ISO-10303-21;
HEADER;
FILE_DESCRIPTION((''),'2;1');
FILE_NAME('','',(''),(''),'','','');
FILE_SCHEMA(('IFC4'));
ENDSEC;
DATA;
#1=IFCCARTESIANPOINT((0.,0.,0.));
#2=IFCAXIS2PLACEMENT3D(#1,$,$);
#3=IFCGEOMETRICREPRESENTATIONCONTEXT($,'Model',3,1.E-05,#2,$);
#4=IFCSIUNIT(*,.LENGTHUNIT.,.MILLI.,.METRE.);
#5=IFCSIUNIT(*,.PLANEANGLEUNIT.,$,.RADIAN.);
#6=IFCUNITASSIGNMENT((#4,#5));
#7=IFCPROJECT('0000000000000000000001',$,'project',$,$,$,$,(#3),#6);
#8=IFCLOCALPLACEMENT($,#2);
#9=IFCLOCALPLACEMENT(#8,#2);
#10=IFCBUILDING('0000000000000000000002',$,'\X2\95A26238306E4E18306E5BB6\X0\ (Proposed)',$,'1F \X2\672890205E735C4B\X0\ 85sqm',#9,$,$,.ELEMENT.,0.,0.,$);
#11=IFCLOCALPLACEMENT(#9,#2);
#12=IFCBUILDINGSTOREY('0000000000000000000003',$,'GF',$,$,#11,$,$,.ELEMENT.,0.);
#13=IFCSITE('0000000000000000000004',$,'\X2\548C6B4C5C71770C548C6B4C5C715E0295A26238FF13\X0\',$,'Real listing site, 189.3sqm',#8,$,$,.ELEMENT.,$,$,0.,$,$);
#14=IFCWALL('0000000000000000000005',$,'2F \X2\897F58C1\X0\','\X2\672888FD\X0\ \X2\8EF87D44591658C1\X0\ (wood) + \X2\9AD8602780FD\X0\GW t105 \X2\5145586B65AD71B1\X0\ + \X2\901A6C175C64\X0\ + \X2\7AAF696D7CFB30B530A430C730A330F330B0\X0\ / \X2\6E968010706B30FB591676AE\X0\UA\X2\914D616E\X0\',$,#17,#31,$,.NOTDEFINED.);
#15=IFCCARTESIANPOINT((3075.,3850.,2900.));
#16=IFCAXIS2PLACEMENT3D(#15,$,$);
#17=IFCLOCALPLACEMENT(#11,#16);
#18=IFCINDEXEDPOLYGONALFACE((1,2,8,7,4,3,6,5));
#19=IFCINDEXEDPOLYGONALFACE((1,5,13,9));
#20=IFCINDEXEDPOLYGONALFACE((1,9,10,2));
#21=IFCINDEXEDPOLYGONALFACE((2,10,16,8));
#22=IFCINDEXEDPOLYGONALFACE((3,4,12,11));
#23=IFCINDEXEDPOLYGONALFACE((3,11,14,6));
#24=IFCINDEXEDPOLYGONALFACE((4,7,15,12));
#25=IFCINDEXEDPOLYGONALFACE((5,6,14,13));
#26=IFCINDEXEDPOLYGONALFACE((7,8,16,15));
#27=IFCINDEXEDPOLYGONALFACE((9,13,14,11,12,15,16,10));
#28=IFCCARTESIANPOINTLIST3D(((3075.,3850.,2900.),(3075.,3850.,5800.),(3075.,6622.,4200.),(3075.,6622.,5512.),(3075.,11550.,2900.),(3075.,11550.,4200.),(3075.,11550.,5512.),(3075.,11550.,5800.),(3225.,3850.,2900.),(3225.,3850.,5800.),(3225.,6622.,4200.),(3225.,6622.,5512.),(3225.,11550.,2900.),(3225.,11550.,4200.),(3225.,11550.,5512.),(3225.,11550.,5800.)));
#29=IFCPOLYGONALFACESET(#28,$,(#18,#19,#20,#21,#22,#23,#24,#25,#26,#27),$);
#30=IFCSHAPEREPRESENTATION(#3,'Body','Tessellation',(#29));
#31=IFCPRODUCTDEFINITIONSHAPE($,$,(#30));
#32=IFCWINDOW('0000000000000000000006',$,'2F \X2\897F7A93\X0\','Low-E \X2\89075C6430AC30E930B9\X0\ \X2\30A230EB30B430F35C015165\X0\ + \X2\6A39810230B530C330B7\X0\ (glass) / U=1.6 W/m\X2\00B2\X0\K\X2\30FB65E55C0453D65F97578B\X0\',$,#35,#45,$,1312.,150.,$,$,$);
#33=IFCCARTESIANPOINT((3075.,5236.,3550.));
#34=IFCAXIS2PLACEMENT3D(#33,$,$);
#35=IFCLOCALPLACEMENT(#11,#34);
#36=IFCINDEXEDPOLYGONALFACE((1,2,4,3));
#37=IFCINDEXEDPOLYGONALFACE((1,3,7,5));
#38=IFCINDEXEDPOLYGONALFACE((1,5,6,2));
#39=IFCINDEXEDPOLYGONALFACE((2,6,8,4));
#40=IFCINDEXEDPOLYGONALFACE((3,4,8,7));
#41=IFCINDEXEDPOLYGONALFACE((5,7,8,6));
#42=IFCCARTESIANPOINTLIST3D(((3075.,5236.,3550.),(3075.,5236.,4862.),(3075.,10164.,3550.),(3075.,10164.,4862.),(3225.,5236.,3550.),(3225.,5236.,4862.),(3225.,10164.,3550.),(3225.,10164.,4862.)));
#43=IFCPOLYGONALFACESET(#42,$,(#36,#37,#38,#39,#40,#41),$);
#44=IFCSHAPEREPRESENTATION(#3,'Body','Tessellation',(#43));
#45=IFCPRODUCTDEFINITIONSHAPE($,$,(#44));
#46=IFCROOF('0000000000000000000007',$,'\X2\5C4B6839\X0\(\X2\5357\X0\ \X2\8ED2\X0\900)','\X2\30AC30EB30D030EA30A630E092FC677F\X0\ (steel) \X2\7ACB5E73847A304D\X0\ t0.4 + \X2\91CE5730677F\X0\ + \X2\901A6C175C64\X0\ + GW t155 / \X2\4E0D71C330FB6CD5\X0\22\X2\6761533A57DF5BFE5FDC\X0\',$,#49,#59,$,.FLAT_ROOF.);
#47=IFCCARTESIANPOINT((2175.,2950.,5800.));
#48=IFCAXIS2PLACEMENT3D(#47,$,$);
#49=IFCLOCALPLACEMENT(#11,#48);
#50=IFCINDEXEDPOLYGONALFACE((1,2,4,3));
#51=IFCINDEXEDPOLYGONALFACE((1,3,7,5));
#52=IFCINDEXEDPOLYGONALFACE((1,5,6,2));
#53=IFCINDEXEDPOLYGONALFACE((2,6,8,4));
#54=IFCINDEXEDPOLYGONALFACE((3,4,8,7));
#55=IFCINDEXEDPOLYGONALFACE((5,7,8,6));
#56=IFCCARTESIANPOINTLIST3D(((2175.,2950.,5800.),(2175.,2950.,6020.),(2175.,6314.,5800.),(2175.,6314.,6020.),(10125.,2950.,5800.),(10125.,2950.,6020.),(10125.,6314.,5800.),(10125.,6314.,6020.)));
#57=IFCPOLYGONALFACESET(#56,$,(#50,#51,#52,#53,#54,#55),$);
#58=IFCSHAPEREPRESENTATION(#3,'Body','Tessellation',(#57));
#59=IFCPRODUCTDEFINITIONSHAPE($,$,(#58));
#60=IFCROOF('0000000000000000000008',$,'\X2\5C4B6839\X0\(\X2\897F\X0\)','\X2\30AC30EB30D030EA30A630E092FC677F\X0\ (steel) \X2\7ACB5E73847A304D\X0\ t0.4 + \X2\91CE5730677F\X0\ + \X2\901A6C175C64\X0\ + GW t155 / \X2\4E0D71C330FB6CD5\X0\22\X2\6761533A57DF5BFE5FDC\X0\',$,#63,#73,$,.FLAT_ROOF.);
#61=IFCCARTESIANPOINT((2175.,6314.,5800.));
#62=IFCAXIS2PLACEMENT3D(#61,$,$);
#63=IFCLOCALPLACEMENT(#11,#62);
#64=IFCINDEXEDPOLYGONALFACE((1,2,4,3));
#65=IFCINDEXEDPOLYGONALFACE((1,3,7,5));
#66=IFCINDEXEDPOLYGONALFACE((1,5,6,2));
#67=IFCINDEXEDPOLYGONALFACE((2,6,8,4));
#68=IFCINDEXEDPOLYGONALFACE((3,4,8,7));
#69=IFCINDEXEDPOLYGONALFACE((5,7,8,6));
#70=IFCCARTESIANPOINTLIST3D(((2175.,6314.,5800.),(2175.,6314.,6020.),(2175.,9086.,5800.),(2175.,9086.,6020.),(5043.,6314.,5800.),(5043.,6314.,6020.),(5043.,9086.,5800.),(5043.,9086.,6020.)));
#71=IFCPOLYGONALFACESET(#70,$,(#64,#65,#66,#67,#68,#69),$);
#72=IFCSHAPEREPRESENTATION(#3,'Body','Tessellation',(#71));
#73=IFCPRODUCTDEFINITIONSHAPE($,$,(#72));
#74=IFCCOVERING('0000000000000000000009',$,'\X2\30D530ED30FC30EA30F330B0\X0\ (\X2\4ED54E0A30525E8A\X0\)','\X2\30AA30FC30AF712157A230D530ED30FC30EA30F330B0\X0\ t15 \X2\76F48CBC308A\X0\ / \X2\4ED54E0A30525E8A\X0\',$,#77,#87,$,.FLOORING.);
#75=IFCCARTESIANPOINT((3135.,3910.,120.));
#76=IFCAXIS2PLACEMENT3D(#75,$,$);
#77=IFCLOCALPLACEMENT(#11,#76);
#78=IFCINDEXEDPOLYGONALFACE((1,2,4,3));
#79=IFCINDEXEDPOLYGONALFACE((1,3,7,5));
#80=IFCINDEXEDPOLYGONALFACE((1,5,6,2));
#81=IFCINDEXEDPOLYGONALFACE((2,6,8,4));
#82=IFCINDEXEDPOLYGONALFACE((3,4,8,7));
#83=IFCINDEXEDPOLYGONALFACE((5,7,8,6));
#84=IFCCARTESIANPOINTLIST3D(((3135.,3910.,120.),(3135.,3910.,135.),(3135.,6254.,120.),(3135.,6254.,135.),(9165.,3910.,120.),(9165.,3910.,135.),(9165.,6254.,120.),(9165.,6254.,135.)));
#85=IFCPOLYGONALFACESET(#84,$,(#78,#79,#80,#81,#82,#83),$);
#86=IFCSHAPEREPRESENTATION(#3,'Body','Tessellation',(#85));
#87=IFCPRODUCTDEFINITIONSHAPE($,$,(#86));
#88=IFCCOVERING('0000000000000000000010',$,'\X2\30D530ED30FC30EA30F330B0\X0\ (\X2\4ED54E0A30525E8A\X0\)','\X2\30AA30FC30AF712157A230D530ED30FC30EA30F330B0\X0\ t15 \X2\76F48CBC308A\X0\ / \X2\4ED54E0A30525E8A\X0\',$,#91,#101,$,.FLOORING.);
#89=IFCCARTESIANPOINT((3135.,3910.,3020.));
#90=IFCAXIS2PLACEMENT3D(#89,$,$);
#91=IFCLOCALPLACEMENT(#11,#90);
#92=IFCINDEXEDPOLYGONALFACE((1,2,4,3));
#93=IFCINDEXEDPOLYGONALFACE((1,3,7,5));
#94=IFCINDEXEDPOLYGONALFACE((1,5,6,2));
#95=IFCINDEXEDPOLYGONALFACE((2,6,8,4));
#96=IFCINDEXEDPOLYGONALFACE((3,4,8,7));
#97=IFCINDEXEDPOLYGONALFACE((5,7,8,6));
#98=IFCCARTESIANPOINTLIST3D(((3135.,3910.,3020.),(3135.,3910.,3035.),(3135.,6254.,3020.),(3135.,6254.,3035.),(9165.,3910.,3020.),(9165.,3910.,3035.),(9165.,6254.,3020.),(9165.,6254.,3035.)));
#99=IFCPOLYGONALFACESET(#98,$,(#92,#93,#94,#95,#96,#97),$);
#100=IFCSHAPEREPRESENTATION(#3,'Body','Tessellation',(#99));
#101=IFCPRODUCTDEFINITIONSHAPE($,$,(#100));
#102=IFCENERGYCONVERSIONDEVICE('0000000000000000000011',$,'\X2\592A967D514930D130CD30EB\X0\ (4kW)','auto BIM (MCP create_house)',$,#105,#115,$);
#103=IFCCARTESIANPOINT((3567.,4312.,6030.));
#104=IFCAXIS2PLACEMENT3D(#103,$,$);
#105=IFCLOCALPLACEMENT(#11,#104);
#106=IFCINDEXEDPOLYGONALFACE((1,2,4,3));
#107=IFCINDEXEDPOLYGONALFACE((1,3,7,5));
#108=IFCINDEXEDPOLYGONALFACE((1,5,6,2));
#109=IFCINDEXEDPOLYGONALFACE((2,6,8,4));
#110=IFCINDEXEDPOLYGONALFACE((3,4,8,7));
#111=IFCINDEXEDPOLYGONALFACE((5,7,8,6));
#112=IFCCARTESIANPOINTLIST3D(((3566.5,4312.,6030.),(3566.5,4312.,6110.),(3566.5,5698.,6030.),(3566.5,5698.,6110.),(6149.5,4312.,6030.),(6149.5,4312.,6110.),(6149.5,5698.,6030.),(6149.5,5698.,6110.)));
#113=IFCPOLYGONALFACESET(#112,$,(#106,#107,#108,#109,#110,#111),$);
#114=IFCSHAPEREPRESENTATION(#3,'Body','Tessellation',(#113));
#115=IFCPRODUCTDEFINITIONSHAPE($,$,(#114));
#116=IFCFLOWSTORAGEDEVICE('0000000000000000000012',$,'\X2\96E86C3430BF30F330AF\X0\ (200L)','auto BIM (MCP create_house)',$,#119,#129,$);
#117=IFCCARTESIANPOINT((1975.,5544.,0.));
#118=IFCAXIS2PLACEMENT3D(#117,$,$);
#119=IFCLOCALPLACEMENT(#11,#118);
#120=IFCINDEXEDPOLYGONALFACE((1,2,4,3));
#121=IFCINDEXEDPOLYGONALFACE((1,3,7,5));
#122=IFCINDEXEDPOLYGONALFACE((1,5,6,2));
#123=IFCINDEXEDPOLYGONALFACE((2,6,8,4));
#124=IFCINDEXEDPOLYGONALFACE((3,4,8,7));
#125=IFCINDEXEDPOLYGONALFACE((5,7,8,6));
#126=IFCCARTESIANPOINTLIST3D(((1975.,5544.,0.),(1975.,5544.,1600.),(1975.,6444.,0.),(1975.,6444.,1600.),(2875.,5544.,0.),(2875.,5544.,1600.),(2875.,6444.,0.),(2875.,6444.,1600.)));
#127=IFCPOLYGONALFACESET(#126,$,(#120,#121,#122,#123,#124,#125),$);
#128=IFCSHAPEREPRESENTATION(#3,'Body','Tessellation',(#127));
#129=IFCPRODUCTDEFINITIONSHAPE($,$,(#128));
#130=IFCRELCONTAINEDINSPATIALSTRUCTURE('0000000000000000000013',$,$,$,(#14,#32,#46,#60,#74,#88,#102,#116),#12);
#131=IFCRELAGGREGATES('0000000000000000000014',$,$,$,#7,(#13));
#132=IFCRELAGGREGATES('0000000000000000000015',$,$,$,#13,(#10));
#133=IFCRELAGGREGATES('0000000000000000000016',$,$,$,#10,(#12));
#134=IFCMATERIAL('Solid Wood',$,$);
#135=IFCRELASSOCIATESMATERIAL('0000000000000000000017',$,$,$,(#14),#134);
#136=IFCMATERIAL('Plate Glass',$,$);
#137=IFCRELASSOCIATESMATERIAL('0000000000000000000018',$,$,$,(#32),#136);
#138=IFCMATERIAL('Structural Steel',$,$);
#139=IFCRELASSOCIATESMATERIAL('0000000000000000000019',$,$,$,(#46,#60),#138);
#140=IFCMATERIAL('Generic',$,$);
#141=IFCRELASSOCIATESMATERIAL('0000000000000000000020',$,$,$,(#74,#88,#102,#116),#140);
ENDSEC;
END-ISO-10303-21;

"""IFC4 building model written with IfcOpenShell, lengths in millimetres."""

from ifc_helpers import new_model, si_unit, frame, frame_2d, origin, place, context, project, spatial, rectangle, extrude, material, element, fill, save


model = new_model("IFC4")

# Units and contexts
model_context = context("Model", 3, precision=1e-05, world=origin())
ifc_project = project(units=[si_unit("LENGTHUNIT", "METRE", prefix="MILLI"), si_unit("PLANEANGLEUNIT", "RADIAN")], contexts=[model_context])

# Site, building, storey
site_placement = place(None, origin())
site = spatial("IfcSite", under=ifc_project, at=site_placement, Name="和歌山県和歌山市関戸３", ObjectType="Real listing site, 189.3sqm", CompositionType="ELEMENT", RefElevation=0.0)
building_placement = place(site_placement, origin())
building = spatial("IfcBuilding", under=site, at=building_placement, Name="関戸の丘の家 (Proposed)", ObjectType="1F 木造平屋 85sqm", CompositionType="ELEMENT", ElevationOfRefHeight=0.0, ElevationOfTerrain=0.0)
storey_placement = place(building_placement, origin())
storey = spatial("IfcBuildingStorey", under=building, at=storey_placement, Name="GF", CompositionType="ELEMENT", Elevation=0.0)

# Shared definitions
ifc_material_1 = material(Name="Solid Wood")
ifc_material_2 = material(Name="Generic")

# Shared definitions
ifc_material_3 = material(Name="Plate Glass")

# Wall, opening, window
wall_1_placement = place(storey_placement, frame((3075.0, 3850.0, 2900.0)))
wall_1 = element("IfcWall", 1, at=wall_1_placement, inside=storey, material=ifc_material_1, Name="2F 西壁", Description="木製 軸組外壁 (wood) + 高性能GW t105 充填断熱 + 通気層 + 窯業系サイディング / 準耐火・外皮UA配慮", PredefinedType="NOTDEFINED", context=model_context, shape_type="SweptSolid", body=[
    extrude(rectangle(XDim=150.0, YDim=7700.0, at=frame_2d((75.0, 3850.0))), frame((3075.0, 3850.0, 2900.0)), (0.0, 0.0, 1.0), 2900.0),
])
opening_1_placement = place(storey_placement, frame((3075.0, 5236.0, 3550.0)))
opening_1 = element("IfcOpeningElement", 2, at=opening_1_placement, cuts=wall_1, PredefinedType="NOTDEFINED", context=model_context, shape_type="SweptSolid", body=[
    extrude(rectangle(XDim=150.0, YDim=4928.0, at=frame_2d((75.0, 2464.0))), frame((3075.0, 5236.0, 3550.0)), (0.0, 0.0, 1.0), 1312.0),
])
window_1_placement = place(storey_placement, frame((3075.0, 5236.0, 3550.0)))
window_1 = element("IfcWindow", 3, at=window_1_placement, inside=storey, material=ifc_material_3, Name="2F 西窓", Description="Low-E 複層ガラス アルゴン封入 + 樹脂サッシ (glass) / U=1.6 W/m²K・日射取得型", OverallHeight=1312.0, OverallWidth=150.0, context=model_context, shape_type="SweptSolid", body=[
    extrude(rectangle(XDim=150.0, YDim=4928.0, at=frame_2d((75.0, 2464.0))), frame((3075.0, 5236.0, 3550.0)), (0.0, 0.0, 1.0), 1312.0),
])
fill(opening_1, window_1)

# Roofs
ifc_material_4 = material(Name="Structural Steel")
roof_1_placement = place(storey_placement, frame((2175.0, 2950.0, 5800.0)))
element("IfcRoof", 4, at=roof_1_placement, inside=storey, material=ifc_material_4, Name="屋根(南 軒900)", Description="ガルバリウム鋼板 (steel) 立平葺き t0.4 + 野地板 + 通気層 + GW t155 / 不燃・法22条区域対応", PredefinedType="FLAT_ROOF", context=model_context, shape_type="SweptSolid", body=[
    extrude(rectangle(XDim=7950.0, YDim=3364.0, at=frame_2d((3975.0, 1682.0))), frame((2175.0, 2950.0, 5800.0)), (0.0, 0.0, 1.0), 220.0),
])
roof_2_placement = place(storey_placement, frame((2175.0, 6314.0, 5800.0)))
element("IfcRoof", 5, at=roof_2_placement, inside=storey, material=ifc_material_4, Name="屋根(西)", Description="ガルバリウム鋼板 (steel) 立平葺き t0.4 + 野地板 + 通気層 + GW t155 / 不燃・法22条区域対応", PredefinedType="FLAT_ROOF", context=model_context, shape_type="SweptSolid", body=[
    extrude(rectangle(XDim=2868.0, YDim=2772.0, at=frame_2d((1434.0, 1386.0))), frame((2175.0, 6314.0, 5800.0)), (0.0, 0.0, 1.0), 220.0),
])

# Coverings
covering_1_placement = place(storey_placement, frame((3135.0, 3910.0, 120.0)))
element("IfcCovering", 6, at=covering_1_placement, inside=storey, material=ifc_material_2, Name="フローリング (仕上げ床)", Description="オーク無垢フローリング t15 直貼り / 仕上げ床", PredefinedType="FLOORING", context=model_context, shape_type="SweptSolid", body=[
    extrude(rectangle(XDim=6030.0, YDim=2344.0, at=frame_2d((3015.0, 1172.0))), frame((3135.0, 3910.0, 120.0)), (0.0, 0.0, 1.0), 15.0),
])
covering_2_placement = place(storey_placement, frame((3135.0, 3910.0, 3020.0)))
element("IfcCovering", 7, at=covering_2_placement, inside=storey, material=ifc_material_2, Name="フローリング (仕上げ床)", Description="オーク無垢フローリング t15 直貼り / 仕上げ床", PredefinedType="FLOORING", context=model_context, shape_type="SweptSolid", body=[
    extrude(rectangle(XDim=6030.0, YDim=2344.0, at=frame_2d((3015.0, 1172.0))), frame((3135.0, 3910.0, 3020.0)), (0.0, 0.0, 1.0), 15.0),
])

# Energy conversion device
energy_conversion_device_placement = place(storey_placement, frame((3567.0, 4312.0, 6030.0)))
element("IfcEnergyConversionDevice", 8, at=energy_conversion_device_placement, inside=storey, material=ifc_material_2, Name="太陽光パネル (4kW)", Description="auto BIM (MCP create_house)", context=model_context, shape_type="SweptSolid", body=[
    extrude(rectangle(XDim=2583.0, YDim=1386.0, at=frame_2d((1291.0, 693.0))), frame((3567.0, 4312.0, 6030.0)), (0.0, 0.0, 1.0), 80.0),
])

# Flow storage device
flow_storage_device_placement = place(storey_placement, frame((1975.0, 5544.0, 0.0)))
element("IfcFlowStorageDevice", 9, at=flow_storage_device_placement, inside=storey, material=ifc_material_2, Name="雨水タンク (200L)", Description="auto BIM (MCP create_house)", context=model_context, shape_type="SweptSolid", body=[
    extrude(rectangle(XDim=900.0, YDim=900.0, at=frame_2d((450.0, 450.0))), frame((1975.0, 5544.0, 0.0)), (0.0, 0.0, 1.0), 1600.0),
])

save(model, "model.ifc")
